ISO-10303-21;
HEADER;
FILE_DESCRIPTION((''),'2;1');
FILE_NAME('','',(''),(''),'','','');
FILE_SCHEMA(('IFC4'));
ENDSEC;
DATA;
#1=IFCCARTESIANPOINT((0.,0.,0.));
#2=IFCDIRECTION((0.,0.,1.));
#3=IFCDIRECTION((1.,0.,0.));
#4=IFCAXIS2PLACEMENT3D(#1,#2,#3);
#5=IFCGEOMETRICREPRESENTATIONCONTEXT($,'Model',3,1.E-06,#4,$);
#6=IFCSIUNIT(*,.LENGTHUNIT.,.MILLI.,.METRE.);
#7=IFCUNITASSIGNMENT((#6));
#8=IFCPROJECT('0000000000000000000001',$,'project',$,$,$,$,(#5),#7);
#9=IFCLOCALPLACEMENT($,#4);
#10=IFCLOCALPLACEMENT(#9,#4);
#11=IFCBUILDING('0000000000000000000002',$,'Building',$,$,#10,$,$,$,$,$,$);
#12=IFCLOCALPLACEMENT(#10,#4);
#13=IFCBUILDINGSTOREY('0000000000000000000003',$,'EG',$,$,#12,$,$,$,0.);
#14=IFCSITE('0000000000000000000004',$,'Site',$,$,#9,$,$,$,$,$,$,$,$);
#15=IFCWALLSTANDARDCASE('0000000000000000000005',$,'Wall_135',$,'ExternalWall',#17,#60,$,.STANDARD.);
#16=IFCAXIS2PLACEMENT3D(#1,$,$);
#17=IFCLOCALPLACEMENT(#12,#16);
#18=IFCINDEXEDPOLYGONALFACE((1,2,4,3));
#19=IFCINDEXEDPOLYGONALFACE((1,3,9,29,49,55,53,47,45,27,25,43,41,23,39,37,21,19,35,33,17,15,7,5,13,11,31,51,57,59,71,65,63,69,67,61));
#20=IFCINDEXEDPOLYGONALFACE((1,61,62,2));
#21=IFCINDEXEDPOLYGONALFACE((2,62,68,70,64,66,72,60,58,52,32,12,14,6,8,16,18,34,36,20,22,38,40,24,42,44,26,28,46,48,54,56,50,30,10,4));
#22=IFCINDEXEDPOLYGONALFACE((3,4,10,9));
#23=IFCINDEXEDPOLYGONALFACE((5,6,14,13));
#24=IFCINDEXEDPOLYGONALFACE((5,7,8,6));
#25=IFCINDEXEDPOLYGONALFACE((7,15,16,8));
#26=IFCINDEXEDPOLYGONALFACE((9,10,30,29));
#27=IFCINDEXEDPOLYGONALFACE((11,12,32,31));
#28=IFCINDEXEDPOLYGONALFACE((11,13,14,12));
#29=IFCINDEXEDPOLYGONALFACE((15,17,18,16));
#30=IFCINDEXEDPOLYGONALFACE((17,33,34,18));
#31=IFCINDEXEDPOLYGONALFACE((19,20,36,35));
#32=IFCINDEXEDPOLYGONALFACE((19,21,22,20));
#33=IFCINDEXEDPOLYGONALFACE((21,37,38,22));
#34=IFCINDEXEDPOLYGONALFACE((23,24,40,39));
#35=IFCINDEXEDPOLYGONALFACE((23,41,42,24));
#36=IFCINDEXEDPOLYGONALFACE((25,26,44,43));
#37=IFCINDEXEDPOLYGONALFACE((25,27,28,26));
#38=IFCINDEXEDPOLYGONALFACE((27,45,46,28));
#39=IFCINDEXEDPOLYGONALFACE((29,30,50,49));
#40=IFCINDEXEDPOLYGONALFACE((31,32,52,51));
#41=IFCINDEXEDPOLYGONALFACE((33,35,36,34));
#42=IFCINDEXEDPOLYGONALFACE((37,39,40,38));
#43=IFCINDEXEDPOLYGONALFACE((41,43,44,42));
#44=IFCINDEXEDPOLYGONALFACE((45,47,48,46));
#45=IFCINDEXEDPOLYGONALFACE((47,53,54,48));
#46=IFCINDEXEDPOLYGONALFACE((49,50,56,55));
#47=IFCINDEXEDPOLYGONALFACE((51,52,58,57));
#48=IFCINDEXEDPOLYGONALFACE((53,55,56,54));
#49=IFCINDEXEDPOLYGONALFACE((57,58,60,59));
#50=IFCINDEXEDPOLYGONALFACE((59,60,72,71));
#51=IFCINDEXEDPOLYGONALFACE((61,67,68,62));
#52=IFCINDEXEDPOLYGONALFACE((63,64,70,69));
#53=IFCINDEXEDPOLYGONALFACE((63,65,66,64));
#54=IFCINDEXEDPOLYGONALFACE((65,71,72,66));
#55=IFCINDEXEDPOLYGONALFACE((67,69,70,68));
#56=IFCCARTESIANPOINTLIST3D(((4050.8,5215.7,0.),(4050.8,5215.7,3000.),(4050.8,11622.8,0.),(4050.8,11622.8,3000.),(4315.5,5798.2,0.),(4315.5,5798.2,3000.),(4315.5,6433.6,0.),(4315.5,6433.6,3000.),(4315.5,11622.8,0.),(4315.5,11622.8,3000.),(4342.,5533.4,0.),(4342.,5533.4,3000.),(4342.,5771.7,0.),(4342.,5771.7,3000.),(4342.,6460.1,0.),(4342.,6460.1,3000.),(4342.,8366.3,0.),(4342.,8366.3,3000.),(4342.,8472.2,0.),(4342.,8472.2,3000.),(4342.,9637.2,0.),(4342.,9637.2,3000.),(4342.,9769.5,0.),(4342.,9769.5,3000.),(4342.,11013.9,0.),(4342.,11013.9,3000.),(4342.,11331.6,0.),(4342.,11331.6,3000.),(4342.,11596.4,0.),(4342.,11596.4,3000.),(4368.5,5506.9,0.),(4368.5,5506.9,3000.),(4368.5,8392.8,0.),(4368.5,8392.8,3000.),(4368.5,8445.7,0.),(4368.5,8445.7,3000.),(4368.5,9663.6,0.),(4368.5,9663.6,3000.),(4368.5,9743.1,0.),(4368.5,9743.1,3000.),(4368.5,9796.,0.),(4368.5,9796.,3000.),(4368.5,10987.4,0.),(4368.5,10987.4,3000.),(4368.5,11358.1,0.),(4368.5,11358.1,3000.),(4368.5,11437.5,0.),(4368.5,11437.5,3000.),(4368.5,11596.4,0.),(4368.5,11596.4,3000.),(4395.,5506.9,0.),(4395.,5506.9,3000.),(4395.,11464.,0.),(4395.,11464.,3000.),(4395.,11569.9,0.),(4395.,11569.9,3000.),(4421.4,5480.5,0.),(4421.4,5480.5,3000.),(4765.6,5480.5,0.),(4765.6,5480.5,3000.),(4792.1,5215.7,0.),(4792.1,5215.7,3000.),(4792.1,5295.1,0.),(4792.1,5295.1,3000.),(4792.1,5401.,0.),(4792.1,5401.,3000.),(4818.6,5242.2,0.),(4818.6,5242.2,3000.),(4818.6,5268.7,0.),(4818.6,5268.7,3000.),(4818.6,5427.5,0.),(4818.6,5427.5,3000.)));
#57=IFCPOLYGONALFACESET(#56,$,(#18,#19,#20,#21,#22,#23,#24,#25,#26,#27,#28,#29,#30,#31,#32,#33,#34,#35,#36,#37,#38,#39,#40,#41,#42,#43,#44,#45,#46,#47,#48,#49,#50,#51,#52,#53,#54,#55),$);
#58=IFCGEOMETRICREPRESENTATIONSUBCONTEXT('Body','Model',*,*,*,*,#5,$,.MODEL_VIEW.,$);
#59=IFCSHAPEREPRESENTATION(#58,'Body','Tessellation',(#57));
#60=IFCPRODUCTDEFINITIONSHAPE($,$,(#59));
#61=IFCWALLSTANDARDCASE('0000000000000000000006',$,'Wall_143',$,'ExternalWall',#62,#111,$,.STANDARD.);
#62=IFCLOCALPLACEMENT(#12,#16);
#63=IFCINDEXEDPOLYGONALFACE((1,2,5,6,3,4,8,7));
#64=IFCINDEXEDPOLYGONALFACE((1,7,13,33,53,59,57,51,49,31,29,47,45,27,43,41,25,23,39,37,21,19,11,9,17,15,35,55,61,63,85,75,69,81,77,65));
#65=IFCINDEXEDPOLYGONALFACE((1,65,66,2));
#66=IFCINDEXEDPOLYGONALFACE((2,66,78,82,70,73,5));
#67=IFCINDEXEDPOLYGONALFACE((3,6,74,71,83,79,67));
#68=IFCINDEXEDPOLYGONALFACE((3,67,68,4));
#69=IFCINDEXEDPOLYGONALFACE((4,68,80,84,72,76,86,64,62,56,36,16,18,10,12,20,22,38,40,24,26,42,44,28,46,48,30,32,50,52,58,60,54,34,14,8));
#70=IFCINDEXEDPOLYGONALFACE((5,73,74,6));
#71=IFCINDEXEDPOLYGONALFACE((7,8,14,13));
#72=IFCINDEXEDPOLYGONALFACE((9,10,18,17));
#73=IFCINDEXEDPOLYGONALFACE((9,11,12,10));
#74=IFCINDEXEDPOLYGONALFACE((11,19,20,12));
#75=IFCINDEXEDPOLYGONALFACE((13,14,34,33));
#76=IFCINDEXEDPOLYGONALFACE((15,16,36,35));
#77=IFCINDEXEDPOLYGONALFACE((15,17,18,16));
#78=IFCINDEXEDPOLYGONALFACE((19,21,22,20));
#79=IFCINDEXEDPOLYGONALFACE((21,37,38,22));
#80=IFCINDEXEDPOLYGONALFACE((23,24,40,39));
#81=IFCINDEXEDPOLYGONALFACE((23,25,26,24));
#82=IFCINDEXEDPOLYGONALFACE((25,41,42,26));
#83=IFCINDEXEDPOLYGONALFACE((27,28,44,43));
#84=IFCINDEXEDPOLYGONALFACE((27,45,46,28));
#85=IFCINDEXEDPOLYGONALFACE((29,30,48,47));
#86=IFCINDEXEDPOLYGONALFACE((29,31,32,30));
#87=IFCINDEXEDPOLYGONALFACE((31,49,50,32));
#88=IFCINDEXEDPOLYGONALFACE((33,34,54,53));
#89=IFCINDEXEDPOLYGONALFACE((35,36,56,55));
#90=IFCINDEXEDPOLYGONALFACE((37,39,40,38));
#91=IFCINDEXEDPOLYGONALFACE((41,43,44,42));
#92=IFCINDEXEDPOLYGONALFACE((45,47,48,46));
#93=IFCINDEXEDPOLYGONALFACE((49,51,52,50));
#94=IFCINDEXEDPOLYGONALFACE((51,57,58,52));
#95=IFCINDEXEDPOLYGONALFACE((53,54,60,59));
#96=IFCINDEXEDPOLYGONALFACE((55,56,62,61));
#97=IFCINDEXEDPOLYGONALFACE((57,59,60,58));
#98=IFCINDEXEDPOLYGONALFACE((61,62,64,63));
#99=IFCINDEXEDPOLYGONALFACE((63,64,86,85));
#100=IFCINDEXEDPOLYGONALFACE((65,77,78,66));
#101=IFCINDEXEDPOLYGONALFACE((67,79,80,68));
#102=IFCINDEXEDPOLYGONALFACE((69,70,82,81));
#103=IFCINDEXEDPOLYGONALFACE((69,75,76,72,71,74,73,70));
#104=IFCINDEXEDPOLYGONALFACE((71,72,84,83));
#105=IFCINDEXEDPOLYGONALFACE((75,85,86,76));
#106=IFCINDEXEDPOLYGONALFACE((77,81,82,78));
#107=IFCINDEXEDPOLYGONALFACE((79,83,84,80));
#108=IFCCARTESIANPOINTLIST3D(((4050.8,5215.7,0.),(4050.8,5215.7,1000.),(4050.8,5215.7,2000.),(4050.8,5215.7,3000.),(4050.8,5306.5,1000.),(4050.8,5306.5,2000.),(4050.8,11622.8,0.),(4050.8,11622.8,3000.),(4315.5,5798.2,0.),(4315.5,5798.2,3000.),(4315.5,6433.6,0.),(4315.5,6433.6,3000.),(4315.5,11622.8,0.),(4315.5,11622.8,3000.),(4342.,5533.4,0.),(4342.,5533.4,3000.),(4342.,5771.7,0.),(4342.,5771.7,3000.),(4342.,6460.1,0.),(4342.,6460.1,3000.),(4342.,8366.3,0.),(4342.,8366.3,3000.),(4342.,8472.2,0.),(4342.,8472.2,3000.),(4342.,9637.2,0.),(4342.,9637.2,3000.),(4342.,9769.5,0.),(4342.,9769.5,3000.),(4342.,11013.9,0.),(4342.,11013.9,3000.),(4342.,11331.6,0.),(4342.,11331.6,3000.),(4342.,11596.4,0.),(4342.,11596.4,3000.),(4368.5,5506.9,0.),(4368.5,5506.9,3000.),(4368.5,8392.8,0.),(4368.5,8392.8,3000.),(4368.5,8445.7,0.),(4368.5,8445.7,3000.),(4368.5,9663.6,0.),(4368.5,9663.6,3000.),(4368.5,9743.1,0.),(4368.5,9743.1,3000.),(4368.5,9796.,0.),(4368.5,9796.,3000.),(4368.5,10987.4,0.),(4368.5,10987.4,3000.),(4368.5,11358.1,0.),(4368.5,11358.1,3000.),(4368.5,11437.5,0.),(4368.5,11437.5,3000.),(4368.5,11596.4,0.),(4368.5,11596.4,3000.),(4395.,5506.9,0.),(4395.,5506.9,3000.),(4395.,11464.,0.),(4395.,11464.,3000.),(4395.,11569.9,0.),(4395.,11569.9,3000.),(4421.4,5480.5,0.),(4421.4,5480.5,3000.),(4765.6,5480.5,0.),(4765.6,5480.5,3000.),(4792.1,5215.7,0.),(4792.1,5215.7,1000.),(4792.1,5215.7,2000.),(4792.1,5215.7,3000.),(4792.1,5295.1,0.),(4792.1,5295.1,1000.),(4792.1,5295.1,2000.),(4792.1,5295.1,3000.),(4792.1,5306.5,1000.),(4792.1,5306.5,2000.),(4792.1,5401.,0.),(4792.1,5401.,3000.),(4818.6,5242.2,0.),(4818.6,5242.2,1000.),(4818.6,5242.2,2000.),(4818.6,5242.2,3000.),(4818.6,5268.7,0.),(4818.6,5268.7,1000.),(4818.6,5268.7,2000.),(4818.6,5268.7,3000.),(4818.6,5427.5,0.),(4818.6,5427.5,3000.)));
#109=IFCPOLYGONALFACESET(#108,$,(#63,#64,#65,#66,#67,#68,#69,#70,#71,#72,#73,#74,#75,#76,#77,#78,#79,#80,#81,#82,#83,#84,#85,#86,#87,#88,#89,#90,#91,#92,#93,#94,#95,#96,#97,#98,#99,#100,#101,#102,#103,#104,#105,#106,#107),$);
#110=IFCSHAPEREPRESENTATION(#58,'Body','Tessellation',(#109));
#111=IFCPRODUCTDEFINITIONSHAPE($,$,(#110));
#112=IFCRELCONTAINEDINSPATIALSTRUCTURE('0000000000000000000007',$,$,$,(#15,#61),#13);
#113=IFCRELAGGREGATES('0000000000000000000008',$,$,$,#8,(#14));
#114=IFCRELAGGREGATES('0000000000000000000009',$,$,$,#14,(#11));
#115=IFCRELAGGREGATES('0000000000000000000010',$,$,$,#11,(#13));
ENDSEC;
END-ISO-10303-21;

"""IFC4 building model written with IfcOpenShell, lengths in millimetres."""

from ifc_helpers import new_model, si_unit, frame, origin_with_axes, place, context, subcontext, project, spatial, polyline, rectangle, outline, extrude, element, save


model = new_model("IFC4")

# Units and contexts
model_context = context("Model", 3, precision=1e-06, world=origin_with_axes())
body_context = subcontext(model_context, "Body", "Model", "MODEL_VIEW")
ifc_project = project(units=[si_unit("LENGTHUNIT", "METRE", prefix="MILLI")], contexts=[model_context])

# Site, building, storey
site_placement = place(None, origin_with_axes())
site = spatial("IfcSite", under=ifc_project, at=site_placement, Name="Site")
building_placement = place(site_placement, origin_with_axes())
building = spatial("IfcBuilding", under=site, at=building_placement, Name="Building")
storey_placement = place(building_placement, origin_with_axes())
storey = spatial("IfcBuildingStorey", under=building, at=storey_placement, Name="EG", Elevation=0.0)

# Wall
for number, where, z_axis, x_axis, name in (
    (1, (0.0, 0.0, 0.0), (0.0, 0.0, 1.0), (1.0, 0.0, 0.0), "Wall_135"),
):
    element("IfcWallStandardCase", number, at=place(storey_placement, frame(where, z_axis=z_axis, x_axis=x_axis)), inside=storey, Name=name, ObjectType="ExternalWall", PredefinedType="STANDARD", context=body_context, shape_type="SweptSolid", body=[
        extrude(outline(polyline([(4050.8, 5215.7, 0.0), (4050.8, 11622.8, 0.0), (4315.5, 11622.8, 0.0), (4342.0, 11596.4, 0.0), (4368.5, 11596.4, 0.0), (4395.0, 11569.9, 0.0), (4395.0, 11464.0, 0.0), (4368.5, 11437.5, 0.0), (4368.5, 11358.1, 0.0), (4342.0, 11331.6, 0.0), (4342.0, 11013.9, 0.0), (4368.5, 10987.4, 0.0), (4368.5, 9796.0, 0.0), (4342.0, 9769.5, 0.0), (4368.5, 9743.1, 0.0), (4368.5, 9663.6, 0.0), (4342.0, 9637.2, 0.0), (4342.0, 8472.2, 0.0), (4368.5, 8445.7, 0.0), (4368.5, 8392.8, 0.0), (4342.0, 8366.3, 0.0), (4342.0, 6460.1, 0.0), (4315.5, 6433.6, 0.0), (4315.5, 5798.2, 0.0), (4342.0, 5771.7, 0.0), (4342.0, 5533.4, 0.0), (4368.5, 5506.9, 0.0), (4395.0, 5506.9, 0.0), (4421.4, 5480.5, 0.0), (4765.6, 5480.5, 0.0), (4818.6, 5427.5, 0.0), (4792.1, 5401.0, 0.0), (4792.1, 5295.1, 0.0), (4818.6, 5268.7, 0.0), (4818.6, 5242.2, 0.0), (4792.1, 5215.7, 0.0), (4050.8, 5215.7, 0.0)])), origin_with_axes(), (0.0, 0.0, 1.0), 3000.0),
    ])

# Wall, opening
wall_1_placement = place(storey_placement, origin_with_axes())
wall_1 = element("IfcWallStandardCase", 2, at=wall_1_placement, inside=storey, Name="Wall_143", ObjectType="ExternalWall", PredefinedType="STANDARD", context=body_context, shape_type="SweptSolid", body=[
    extrude(outline(polyline([(4050.8, 5215.7, 0.0), (4050.8, 11622.8, 0.0), (4315.5, 11622.8, 0.0), (4342.0, 11596.4, 0.0), (4368.5, 11596.4, 0.0), (4395.0, 11569.9, 0.0), (4395.0, 11464.0, 0.0), (4368.5, 11437.5, 0.0), (4368.5, 11358.1, 0.0), (4342.0, 11331.6, 0.0), (4342.0, 11013.9, 0.0), (4368.5, 10987.4, 0.0), (4368.5, 9796.0, 0.0), (4342.0, 9769.5, 0.0), (4368.5, 9743.1, 0.0), (4368.5, 9663.6, 0.0), (4342.0, 9637.2, 0.0), (4342.0, 8472.2, 0.0), (4368.5, 8445.7, 0.0), (4368.5, 8392.8, 0.0), (4342.0, 8366.3, 0.0), (4342.0, 6460.1, 0.0), (4315.5, 6433.6, 0.0), (4315.5, 5798.2, 0.0), (4342.0, 5771.7, 0.0), (4342.0, 5533.4, 0.0), (4368.5, 5506.9, 0.0), (4395.0, 5506.9, 0.0), (4421.4, 5480.5, 0.0), (4765.6, 5480.5, 0.0), (4818.6, 5427.5, 0.0), (4792.1, 5401.0, 0.0), (4792.1, 5295.1, 0.0), (4818.6, 5268.7, 0.0), (4818.6, 5242.2, 0.0), (4792.1, 5215.7, 0.0), (4050.8, 5215.7, 0.0)])), origin_with_axes(), (0.0, 0.0, 1.0), 3000.0),
])
opening_1_placement = place(wall_1_placement, origin_with_axes())
element("IfcOpeningElement", 3, at=opening_1_placement, inside=storey, cuts=wall_1, context=body_context, shape_type="SweptSolid", body=[
    extrude(rectangle(XDim=2721.7, YDim=115.0), frame((4778.6, 5249.0, 1000.0), z_axis=(0.0, 0.0, 1.0), x_axis=(1.0, 0.0, 0.0)), (0.0, 0.0, 1.0), 1000.0),
])

save(model, "model.ifc")
